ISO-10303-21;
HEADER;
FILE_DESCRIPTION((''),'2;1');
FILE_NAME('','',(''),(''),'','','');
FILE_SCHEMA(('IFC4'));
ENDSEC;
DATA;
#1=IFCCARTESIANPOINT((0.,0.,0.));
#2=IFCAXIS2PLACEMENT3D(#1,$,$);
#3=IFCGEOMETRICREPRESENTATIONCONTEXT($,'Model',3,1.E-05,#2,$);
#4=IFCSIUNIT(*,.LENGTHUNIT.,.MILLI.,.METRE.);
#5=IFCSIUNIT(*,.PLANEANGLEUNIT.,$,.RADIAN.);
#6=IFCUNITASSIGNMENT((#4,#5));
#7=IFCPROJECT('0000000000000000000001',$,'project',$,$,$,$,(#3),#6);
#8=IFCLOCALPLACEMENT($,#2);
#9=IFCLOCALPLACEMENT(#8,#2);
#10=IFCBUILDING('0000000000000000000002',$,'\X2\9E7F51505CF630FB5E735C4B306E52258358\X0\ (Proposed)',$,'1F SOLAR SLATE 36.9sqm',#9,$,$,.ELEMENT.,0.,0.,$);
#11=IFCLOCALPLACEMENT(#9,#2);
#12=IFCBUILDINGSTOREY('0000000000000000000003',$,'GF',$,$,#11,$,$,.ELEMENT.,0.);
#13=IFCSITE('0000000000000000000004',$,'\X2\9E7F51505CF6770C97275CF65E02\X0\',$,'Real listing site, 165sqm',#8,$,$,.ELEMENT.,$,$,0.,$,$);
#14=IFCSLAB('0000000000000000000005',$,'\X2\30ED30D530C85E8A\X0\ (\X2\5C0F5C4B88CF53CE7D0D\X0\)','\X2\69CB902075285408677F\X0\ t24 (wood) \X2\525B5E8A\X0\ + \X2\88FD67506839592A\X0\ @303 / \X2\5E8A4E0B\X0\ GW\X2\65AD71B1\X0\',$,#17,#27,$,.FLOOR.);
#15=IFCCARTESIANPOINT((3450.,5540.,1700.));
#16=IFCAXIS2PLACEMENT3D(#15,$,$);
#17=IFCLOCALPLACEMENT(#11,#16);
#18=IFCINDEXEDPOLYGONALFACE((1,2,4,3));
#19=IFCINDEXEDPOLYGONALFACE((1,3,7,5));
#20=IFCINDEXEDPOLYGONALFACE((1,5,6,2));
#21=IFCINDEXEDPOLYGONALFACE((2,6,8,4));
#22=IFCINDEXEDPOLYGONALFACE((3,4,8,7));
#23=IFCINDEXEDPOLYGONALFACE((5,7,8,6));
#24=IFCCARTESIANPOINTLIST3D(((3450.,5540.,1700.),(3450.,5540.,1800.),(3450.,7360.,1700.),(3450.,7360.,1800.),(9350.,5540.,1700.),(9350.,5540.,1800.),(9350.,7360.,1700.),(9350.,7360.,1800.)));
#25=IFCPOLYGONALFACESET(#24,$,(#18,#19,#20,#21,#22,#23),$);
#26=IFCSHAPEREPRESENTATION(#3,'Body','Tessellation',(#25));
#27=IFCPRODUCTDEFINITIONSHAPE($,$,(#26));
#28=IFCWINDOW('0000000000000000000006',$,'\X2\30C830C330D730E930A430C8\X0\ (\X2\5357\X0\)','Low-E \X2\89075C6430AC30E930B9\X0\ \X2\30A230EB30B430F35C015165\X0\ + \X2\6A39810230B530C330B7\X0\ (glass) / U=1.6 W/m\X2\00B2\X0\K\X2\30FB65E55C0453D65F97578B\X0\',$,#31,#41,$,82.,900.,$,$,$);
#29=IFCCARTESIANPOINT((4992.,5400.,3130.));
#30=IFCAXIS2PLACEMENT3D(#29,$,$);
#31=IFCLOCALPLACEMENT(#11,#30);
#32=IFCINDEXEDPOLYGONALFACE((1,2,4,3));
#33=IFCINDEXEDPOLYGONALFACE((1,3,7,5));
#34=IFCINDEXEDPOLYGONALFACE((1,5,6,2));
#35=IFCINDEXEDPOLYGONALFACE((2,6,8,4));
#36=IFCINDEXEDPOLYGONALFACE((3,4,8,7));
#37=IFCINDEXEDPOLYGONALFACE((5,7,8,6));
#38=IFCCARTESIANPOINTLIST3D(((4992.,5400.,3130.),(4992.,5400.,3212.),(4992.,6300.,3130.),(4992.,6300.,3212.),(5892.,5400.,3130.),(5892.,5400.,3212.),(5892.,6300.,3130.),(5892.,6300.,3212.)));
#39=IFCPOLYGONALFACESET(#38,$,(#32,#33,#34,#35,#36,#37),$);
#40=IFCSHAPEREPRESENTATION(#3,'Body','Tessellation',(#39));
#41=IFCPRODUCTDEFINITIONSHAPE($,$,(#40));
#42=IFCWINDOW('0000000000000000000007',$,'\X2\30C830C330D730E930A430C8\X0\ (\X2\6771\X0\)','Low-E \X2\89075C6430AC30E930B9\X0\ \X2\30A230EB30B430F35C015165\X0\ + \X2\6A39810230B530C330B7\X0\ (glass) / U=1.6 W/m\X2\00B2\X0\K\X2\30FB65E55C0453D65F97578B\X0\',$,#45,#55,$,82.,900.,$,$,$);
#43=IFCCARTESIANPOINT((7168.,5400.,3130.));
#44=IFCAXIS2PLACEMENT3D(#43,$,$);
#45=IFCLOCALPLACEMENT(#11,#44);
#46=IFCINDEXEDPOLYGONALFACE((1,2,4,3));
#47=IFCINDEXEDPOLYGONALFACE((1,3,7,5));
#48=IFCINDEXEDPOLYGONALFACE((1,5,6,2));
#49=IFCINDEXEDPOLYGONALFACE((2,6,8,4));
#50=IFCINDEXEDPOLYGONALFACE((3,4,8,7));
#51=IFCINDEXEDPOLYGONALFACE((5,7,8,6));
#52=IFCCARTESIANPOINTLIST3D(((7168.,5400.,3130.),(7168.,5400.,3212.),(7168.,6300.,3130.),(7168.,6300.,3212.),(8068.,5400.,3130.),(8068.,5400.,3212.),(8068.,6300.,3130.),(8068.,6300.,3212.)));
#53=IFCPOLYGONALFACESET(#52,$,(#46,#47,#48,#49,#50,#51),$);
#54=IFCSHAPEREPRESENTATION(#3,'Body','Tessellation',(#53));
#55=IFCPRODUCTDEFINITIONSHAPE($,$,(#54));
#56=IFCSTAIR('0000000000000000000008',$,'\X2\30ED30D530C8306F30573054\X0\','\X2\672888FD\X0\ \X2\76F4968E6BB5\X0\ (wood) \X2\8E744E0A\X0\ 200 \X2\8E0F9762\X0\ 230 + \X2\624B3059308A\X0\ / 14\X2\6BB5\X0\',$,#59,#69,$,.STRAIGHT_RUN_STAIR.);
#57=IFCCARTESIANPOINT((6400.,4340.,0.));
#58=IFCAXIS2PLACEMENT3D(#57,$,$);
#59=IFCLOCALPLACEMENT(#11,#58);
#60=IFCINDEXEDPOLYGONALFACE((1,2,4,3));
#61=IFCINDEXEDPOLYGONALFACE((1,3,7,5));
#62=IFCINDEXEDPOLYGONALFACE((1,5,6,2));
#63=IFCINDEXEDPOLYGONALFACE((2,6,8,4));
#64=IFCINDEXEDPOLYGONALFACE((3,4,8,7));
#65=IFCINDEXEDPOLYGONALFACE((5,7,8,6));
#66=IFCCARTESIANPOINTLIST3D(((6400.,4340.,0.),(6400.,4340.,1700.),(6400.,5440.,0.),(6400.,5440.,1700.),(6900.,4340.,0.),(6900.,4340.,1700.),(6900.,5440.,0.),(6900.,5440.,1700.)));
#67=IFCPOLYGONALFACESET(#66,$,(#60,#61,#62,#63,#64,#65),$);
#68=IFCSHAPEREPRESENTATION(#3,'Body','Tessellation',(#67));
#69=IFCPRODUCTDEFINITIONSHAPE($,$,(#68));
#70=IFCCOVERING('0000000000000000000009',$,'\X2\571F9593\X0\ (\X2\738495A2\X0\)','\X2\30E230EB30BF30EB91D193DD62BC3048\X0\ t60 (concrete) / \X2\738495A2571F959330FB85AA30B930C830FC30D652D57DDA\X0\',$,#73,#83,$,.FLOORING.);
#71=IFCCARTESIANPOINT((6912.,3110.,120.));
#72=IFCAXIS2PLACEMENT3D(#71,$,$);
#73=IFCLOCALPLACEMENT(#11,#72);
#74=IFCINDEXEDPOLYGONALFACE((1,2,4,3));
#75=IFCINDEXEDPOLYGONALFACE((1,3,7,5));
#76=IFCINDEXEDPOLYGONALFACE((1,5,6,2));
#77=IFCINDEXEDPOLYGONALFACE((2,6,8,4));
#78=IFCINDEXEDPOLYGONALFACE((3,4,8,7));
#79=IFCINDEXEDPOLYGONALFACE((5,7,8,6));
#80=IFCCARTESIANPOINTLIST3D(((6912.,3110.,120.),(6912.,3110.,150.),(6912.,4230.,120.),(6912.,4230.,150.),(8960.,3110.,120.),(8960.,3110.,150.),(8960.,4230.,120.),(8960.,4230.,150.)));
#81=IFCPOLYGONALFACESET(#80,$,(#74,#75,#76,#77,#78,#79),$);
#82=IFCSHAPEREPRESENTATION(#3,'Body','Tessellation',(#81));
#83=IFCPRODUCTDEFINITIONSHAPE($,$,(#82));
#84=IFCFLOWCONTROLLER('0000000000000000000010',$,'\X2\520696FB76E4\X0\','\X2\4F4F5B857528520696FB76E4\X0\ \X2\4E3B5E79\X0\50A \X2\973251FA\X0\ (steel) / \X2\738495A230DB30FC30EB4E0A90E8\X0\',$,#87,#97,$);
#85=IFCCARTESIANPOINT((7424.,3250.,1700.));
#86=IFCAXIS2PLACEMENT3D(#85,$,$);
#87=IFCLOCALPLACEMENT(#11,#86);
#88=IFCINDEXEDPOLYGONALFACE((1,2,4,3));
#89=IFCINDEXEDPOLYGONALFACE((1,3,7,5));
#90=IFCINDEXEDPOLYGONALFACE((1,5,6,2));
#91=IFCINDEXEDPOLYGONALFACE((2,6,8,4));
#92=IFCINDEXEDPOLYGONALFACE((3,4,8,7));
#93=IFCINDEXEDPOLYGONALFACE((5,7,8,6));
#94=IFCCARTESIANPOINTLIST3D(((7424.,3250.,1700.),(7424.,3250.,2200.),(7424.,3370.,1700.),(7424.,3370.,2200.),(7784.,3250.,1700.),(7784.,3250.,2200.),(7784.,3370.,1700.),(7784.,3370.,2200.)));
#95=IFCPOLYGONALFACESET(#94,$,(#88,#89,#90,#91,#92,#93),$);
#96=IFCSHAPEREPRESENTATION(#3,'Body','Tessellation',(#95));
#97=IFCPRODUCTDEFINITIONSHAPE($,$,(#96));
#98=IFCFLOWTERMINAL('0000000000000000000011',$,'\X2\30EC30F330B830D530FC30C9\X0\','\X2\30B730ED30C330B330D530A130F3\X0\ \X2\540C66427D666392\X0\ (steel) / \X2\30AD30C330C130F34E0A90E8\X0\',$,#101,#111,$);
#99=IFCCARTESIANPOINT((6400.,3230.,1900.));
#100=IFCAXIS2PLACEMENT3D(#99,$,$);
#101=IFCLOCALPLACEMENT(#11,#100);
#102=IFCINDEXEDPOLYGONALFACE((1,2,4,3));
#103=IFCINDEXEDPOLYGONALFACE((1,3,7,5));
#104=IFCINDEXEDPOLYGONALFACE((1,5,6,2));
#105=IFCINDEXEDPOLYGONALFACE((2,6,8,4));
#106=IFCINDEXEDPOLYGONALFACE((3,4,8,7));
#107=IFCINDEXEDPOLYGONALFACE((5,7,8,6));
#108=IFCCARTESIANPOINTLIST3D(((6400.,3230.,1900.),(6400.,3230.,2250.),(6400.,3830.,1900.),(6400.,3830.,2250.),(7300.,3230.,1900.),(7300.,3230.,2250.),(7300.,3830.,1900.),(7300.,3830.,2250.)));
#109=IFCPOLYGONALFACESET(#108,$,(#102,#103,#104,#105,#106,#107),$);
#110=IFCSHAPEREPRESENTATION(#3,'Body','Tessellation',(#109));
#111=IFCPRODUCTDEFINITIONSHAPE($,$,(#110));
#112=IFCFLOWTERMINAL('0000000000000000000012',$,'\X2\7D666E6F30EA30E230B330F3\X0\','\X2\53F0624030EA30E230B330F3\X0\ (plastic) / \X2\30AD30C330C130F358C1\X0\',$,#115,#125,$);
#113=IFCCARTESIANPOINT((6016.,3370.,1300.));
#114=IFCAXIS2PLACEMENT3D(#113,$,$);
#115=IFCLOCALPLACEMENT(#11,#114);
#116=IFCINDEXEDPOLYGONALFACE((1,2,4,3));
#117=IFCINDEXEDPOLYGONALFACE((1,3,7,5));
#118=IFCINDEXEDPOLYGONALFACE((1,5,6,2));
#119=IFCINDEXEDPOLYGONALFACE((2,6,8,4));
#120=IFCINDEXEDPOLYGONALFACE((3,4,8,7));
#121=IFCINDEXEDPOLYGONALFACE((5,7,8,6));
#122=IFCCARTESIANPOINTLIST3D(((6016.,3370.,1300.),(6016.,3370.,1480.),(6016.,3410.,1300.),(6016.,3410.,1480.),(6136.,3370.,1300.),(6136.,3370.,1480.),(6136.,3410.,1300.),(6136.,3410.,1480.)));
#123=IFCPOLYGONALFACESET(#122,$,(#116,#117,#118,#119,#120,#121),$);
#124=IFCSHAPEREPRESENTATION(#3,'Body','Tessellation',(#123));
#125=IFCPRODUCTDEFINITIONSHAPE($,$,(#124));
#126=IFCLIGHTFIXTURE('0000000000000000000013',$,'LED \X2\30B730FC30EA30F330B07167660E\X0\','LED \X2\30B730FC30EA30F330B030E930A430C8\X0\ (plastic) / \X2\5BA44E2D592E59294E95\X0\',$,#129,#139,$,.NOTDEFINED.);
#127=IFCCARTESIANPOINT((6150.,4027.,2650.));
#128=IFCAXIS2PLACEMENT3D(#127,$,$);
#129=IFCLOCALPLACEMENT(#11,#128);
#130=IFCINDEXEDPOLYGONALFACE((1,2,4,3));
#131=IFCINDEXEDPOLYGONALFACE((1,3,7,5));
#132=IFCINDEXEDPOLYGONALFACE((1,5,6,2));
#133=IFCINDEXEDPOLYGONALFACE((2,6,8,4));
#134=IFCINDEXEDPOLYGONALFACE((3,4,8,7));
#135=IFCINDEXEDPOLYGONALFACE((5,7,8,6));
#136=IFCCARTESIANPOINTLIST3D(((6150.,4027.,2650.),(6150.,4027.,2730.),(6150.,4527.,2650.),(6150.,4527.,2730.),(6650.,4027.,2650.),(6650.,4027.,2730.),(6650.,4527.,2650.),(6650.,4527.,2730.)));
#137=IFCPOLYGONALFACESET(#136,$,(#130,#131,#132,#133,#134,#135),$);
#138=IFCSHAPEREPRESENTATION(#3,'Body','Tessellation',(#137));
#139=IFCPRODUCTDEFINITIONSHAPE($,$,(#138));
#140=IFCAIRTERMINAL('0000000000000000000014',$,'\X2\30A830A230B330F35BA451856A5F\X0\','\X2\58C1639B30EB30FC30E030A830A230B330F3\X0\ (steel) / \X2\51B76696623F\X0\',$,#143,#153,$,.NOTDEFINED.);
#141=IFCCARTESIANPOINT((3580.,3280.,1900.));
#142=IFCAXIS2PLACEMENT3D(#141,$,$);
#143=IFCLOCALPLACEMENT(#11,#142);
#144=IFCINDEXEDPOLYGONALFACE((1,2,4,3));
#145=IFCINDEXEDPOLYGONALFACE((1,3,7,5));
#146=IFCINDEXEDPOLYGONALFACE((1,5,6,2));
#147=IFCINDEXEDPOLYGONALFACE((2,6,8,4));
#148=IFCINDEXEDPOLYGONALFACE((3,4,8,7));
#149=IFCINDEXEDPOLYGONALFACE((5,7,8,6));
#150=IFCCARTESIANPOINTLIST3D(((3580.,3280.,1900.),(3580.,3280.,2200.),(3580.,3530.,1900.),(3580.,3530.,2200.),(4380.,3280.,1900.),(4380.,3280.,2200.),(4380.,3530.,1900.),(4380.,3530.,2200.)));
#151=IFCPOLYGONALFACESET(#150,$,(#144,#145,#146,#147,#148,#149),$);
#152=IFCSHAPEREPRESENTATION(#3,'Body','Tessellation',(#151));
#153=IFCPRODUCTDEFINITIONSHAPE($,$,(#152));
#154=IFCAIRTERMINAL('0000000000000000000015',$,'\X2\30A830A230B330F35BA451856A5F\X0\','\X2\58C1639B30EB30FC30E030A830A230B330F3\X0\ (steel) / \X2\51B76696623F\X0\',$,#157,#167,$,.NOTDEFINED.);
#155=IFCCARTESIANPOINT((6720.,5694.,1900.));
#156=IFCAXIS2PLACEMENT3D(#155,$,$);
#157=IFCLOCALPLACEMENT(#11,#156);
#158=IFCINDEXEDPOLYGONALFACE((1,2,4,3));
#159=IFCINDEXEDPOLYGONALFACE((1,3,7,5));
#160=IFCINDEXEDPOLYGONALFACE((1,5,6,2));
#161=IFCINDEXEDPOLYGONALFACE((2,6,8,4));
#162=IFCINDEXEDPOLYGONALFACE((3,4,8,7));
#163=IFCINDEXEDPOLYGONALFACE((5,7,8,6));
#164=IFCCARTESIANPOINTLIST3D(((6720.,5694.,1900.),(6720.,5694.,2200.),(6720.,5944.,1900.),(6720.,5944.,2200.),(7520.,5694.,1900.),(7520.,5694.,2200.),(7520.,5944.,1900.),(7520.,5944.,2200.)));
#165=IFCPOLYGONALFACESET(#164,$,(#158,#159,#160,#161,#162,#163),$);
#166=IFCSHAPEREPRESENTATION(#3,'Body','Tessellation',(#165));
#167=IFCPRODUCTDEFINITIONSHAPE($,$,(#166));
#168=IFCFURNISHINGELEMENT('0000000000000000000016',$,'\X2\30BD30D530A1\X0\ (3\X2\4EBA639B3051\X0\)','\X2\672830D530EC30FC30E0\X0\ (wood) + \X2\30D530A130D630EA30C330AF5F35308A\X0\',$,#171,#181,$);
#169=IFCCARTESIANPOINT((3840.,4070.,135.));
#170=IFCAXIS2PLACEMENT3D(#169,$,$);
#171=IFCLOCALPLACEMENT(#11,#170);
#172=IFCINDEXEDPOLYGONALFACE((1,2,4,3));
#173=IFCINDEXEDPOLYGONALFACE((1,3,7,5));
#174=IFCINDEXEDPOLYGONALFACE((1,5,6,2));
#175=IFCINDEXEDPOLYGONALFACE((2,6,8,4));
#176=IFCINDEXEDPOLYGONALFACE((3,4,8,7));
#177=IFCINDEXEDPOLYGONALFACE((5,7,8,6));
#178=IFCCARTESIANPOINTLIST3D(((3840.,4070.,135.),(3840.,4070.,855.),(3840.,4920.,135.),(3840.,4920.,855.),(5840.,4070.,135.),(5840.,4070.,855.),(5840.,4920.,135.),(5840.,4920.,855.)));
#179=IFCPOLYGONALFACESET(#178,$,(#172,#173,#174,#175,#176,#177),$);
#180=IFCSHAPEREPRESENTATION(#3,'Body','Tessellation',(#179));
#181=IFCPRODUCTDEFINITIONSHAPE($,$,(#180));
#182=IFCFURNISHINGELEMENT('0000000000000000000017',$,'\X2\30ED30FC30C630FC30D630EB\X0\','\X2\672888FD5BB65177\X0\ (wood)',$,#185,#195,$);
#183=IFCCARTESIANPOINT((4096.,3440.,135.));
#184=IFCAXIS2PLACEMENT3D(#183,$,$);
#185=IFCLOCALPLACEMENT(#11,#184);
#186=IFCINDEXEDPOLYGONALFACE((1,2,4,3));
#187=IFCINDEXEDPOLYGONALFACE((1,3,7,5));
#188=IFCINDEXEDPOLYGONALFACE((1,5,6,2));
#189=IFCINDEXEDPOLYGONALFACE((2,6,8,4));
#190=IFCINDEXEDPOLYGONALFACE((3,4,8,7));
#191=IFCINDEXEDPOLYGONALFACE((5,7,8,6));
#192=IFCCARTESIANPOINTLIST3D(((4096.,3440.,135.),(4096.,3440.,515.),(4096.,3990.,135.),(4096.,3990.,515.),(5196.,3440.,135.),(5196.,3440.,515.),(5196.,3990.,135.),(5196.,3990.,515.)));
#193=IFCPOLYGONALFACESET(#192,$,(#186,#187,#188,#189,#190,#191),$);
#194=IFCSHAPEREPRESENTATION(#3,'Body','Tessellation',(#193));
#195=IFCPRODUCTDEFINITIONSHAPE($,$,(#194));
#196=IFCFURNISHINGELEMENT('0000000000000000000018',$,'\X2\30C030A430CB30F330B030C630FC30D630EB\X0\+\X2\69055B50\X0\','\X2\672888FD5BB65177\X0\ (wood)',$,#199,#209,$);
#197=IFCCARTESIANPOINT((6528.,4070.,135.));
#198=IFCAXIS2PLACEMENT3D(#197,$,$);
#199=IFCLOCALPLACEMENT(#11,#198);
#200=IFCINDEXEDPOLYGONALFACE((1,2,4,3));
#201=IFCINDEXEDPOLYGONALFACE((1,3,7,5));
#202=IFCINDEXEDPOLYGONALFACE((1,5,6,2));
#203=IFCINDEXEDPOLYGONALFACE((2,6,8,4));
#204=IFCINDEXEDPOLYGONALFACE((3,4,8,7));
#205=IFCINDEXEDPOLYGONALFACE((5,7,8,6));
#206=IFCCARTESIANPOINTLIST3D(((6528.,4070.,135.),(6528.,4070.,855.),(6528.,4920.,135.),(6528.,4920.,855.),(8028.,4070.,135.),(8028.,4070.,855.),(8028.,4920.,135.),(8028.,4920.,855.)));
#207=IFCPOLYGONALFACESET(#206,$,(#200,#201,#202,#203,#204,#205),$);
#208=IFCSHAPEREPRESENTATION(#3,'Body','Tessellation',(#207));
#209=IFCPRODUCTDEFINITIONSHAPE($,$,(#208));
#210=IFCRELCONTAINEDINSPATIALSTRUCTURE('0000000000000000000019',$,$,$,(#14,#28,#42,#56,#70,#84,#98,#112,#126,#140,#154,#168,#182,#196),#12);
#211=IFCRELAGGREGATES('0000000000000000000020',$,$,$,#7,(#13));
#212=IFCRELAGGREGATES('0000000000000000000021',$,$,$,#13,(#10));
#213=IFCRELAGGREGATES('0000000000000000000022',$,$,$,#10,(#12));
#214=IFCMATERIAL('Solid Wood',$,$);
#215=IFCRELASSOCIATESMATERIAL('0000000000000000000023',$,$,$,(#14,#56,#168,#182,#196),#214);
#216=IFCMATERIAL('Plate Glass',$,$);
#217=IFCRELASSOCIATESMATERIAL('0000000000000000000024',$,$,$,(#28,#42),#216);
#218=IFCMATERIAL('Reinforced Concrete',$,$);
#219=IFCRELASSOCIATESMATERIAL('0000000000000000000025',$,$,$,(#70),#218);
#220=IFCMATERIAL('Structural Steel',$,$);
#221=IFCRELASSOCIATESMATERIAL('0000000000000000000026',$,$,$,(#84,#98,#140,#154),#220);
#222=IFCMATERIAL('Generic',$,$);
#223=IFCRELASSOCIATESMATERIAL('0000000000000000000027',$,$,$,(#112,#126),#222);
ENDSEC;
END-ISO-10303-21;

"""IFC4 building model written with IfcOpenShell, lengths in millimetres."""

from ifc_helpers import new_model, si_unit, frame, frame_2d, origin, place, context, project, spatial, rectangle, extrude, material, element, save


model = new_model("IFC4")

# Units and contexts
model_context = context("Model", 3, precision=1e-05, world=origin())
ifc_project = project(units=[si_unit("LENGTHUNIT", "METRE", prefix="MILLI"), si_unit("PLANEANGLEUNIT", "RADIAN")], contexts=[model_context])

# Site, building, storey
site_placement = place(None, origin())
site = spatial("IfcSite", under=ifc_project, at=site_placement, Name="鹿児島県霧島市", ObjectType="Real listing site, 165sqm", CompositionType="ELEMENT", RefElevation=0.0)
building_placement = place(site_placement, origin())
building = spatial("IfcBuilding", under=site, at=building_placement, Name="鹿児島・平屋の別荘 (Proposed)", ObjectType="1F SOLAR SLATE 36.9sqm", CompositionType="ELEMENT", ElevationOfRefHeight=0.0, ElevationOfTerrain=0.0)
storey_placement = place(building_placement, origin())
storey = spatial("IfcBuildingStorey", under=building, at=storey_placement, Name="GF", CompositionType="ELEMENT", Elevation=0.0)

# Shared definitions
ifc_material_1 = material(Name="Solid Wood")

# Slab
slab_placement = place(storey_placement, frame((3450.0, 5540.0, 1700.0)))
element("IfcSlab", 1, at=slab_placement, inside=storey, material=ifc_material_1, Name="ロフト床 (小屋裏収納)", Description="構造用合板 t24 (wood) 剛床 + 製材根太 @303 / 床下 GW断熱", PredefinedType="FLOOR", context=model_context, shape_type="SweptSolid", body=[
    extrude(rectangle(XDim=5900.0, YDim=1820.0, at=frame_2d((2950.0, 910.0))), frame((3450.0, 5540.0, 1700.0)), (0.0, 0.0, 1.0), 100.0),
])

# Windows
ifc_material_2 = material(Name="Plate Glass")
window_1_placement = place(storey_placement, frame((4992.0, 5400.0, 3130.0)))
element("IfcWindow", 2, at=window_1_placement, inside=storey, material=ifc_material_2, Name="トップライト (南)", Description="Low-E 複層ガラス アルゴン封入 + 樹脂サッシ (glass) / U=1.6 W/m²K・日射取得型", OverallHeight=82.0, OverallWidth=900.0, context=model_context, shape_type="SweptSolid", body=[
    extrude(rectangle(XDim=900.0, YDim=900.0, at=frame_2d((450.0, 450.0))), frame((4992.0, 5400.0, 3130.0)), (0.0, 0.0, 1.0), 82.0),
])
window_2_placement = place(storey_placement, frame((7168.0, 5400.0, 3130.0)))
element("IfcWindow", 3, at=window_2_placement, inside=storey, material=ifc_material_2, Name="トップライト (東)", Description="Low-E 複層ガラス アルゴン封入 + 樹脂サッシ (glass) / U=1.6 W/m²K・日射取得型", OverallHeight=82.0, OverallWidth=900.0, context=model_context, shape_type="SweptSolid", body=[
    extrude(rectangle(XDim=900.0, YDim=900.0, at=frame_2d((450.0, 450.0))), frame((7168.0, 5400.0, 3130.0)), (0.0, 0.0, 1.0), 82.0),
])

# Stair
stair_placement = place(storey_placement, frame((6400.0, 4340.0, 0.0)))
element("IfcStair", 4, at=stair_placement, inside=storey, material=ifc_material_1, Name="ロフトはしご", Description="木製 直階段 (wood) 蹴上 200 踏面 230 + 手すり / 14段", PredefinedType="STRAIGHT_RUN_STAIR", context=model_context, shape_type="SweptSolid", body=[
    extrude(rectangle(XDim=500.0, YDim=1100.0, at=frame_2d((250.0, 550.0))), frame((6400.0, 4340.0, 0.0)), (0.0, 0.0, 1.0), 1700.0),
])

# Covering
ifc_material_3 = material(Name="Reinforced Concrete")
covering_placement = place(storey_placement, frame((6912.0, 3110.0, 120.0)))
element("IfcCovering", 5, at=covering_placement, inside=storey, material=ifc_material_3, Name="土間 (玄関)", Description="モルタル金鏝押え t60 (concrete) / 玄関土間・薪ストーブ動線", PredefinedType="FLOORING", context=model_context, shape_type="SweptSolid", body=[
    extrude(rectangle(XDim=2048.0, YDim=1120.0, at=frame_2d((1024.0, 560.0))), frame((6912.0, 3110.0, 120.0)), (0.0, 0.0, 1.0), 30.0),
])

# Flow controller
ifc_material_4 = material(Name="Structural Steel")
flow_controller_placement = place(storey_placement, frame((7424.0, 3250.0, 1700.0)))
element("IfcFlowController", 6, at=flow_controller_placement, inside=storey, material=ifc_material_4, Name="分電盤", Description="住宅用分電盤 主幹50A 露出 (steel) / 玄関ホール上部", context=model_context, shape_type="SweptSolid", body=[
    extrude(rectangle(XDim=360.0, YDim=120.0, at=frame_2d((180.0, 60.0))), frame((7424.0, 3250.0, 1700.0)), (0.0, 0.0, 1.0), 500.0),
])

# Flow terminals
flow_terminal_1_placement = place(storey_placement, frame((6400.0, 3230.0, 1900.0)))
element("IfcFlowTerminal", 7, at=flow_terminal_1_placement, inside=storey, material=ifc_material_4, Name="レンジフード", Description="シロッコファン 同時給排 (steel) / キッチン上部", context=model_context, shape_type="SweptSolid", body=[
    extrude(rectangle(XDim=900.0, YDim=600.0, at=frame_2d((450.0, 300.0))), frame((6400.0, 3230.0, 1900.0)), (0.0, 0.0, 1.0), 350.0),
])
ifc_material_5 = material(Name="Generic")
flow_terminal_2_placement = place(storey_placement, frame((6016.0, 3370.0, 1300.0)))
element("IfcFlowTerminal", 8, at=flow_terminal_2_placement, inside=storey, material=ifc_material_5, Name="給湯リモコン", Description="台所リモコン (plastic) / キッチン壁", context=model_context, shape_type="SweptSolid", body=[
    extrude(rectangle(XDim=120.0, YDim=40.0, at=frame_2d((60.0, 20.0))), frame((6016.0, 3370.0, 1300.0)), (0.0, 0.0, 1.0), 180.0),
])

# Light fixture
light_fixture_placement = place(storey_placement, frame((6150.0, 4027.0, 2650.0)))
element("IfcLightFixture", 9, at=light_fixture_placement, inside=storey, material=ifc_material_5, Name="LED シーリング照明", Description="LED シーリングライト (plastic) / 室中央天井", PredefinedType="NOTDEFINED", context=model_context, shape_type="SweptSolid", body=[
    extrude(rectangle(XDim=500.0, YDim=500.0, at=frame_2d((250.0, 250.0))), frame((6150.0, 4027.0, 2650.0)), (0.0, 0.0, 1.0), 80.0),
])

# Air terminals
air_terminal_1_placement = place(storey_placement, frame((3580.0, 3280.0, 1900.0)))
element("IfcAirTerminal", 10, at=air_terminal_1_placement, inside=storey, material=ifc_material_4, Name="エアコン室内機", Description="壁掛ルームエアコン (steel) / 冷暖房", PredefinedType="NOTDEFINED", context=model_context, shape_type="SweptSolid", body=[
    extrude(rectangle(XDim=800.0, YDim=250.0, at=frame_2d((400.0, 125.0))), frame((3580.0, 3280.0, 1900.0)), (0.0, 0.0, 1.0), 300.0),
])
air_terminal_2_placement = place(storey_placement, frame((6720.0, 5694.0, 1900.0)))
element("IfcAirTerminal", 11, at=air_terminal_2_placement, inside=storey, material=ifc_material_4, Name="エアコン室内機", Description="壁掛ルームエアコン (steel) / 冷暖房", PredefinedType="NOTDEFINED", context=model_context, shape_type="SweptSolid", body=[
    extrude(rectangle(XDim=800.0, YDim=250.0, at=frame_2d((400.0, 125.0))), frame((6720.0, 5694.0, 1900.0)), (0.0, 0.0, 1.0), 300.0),
])

# Furnishing elements
furnishing_1_placement = place(storey_placement, frame((3840.0, 4070.0, 135.0)))
element("IfcFurnishingElement", 12, at=furnishing_1_placement, inside=storey, material=ifc_material_1, Name="ソファ (3人掛け)", Description="木フレーム (wood) + ファブリック張り", context=model_context, shape_type="SweptSolid", body=[
    extrude(rectangle(XDim=2000.0, YDim=850.0, at=frame_2d((1000.0, 425.0))), frame((3840.0, 4070.0, 135.0)), (0.0, 0.0, 1.0), 720.0),
])
furnishing_2_placement = place(storey_placement, frame((4096.0, 3440.0, 135.0)))
element("IfcFurnishingElement", 13, at=furnishing_2_placement, inside=storey, material=ifc_material_1, Name="ローテーブル", Description="木製家具 (wood)", context=model_context, shape_type="SweptSolid", body=[
    extrude(rectangle(XDim=1100.0, YDim=550.0, at=frame_2d((550.0, 275.0))), frame((4096.0, 3440.0, 135.0)), (0.0, 0.0, 1.0), 380.0),
])
furnishing_3_placement = place(storey_placement, frame((6528.0, 4070.0, 135.0)))
element("IfcFurnishingElement", 14, at=furnishing_3_placement, inside=storey, material=ifc_material_1, Name="ダイニングテーブル+椅子", Description="木製家具 (wood)", context=model_context, shape_type="SweptSolid", body=[
    extrude(rectangle(XDim=1500.0, YDim=850.0, at=frame_2d((750.0, 425.0))), frame((6528.0, 4070.0, 135.0)), (0.0, 0.0, 1.0), 720.0),
])

save(model, "model.ifc")
